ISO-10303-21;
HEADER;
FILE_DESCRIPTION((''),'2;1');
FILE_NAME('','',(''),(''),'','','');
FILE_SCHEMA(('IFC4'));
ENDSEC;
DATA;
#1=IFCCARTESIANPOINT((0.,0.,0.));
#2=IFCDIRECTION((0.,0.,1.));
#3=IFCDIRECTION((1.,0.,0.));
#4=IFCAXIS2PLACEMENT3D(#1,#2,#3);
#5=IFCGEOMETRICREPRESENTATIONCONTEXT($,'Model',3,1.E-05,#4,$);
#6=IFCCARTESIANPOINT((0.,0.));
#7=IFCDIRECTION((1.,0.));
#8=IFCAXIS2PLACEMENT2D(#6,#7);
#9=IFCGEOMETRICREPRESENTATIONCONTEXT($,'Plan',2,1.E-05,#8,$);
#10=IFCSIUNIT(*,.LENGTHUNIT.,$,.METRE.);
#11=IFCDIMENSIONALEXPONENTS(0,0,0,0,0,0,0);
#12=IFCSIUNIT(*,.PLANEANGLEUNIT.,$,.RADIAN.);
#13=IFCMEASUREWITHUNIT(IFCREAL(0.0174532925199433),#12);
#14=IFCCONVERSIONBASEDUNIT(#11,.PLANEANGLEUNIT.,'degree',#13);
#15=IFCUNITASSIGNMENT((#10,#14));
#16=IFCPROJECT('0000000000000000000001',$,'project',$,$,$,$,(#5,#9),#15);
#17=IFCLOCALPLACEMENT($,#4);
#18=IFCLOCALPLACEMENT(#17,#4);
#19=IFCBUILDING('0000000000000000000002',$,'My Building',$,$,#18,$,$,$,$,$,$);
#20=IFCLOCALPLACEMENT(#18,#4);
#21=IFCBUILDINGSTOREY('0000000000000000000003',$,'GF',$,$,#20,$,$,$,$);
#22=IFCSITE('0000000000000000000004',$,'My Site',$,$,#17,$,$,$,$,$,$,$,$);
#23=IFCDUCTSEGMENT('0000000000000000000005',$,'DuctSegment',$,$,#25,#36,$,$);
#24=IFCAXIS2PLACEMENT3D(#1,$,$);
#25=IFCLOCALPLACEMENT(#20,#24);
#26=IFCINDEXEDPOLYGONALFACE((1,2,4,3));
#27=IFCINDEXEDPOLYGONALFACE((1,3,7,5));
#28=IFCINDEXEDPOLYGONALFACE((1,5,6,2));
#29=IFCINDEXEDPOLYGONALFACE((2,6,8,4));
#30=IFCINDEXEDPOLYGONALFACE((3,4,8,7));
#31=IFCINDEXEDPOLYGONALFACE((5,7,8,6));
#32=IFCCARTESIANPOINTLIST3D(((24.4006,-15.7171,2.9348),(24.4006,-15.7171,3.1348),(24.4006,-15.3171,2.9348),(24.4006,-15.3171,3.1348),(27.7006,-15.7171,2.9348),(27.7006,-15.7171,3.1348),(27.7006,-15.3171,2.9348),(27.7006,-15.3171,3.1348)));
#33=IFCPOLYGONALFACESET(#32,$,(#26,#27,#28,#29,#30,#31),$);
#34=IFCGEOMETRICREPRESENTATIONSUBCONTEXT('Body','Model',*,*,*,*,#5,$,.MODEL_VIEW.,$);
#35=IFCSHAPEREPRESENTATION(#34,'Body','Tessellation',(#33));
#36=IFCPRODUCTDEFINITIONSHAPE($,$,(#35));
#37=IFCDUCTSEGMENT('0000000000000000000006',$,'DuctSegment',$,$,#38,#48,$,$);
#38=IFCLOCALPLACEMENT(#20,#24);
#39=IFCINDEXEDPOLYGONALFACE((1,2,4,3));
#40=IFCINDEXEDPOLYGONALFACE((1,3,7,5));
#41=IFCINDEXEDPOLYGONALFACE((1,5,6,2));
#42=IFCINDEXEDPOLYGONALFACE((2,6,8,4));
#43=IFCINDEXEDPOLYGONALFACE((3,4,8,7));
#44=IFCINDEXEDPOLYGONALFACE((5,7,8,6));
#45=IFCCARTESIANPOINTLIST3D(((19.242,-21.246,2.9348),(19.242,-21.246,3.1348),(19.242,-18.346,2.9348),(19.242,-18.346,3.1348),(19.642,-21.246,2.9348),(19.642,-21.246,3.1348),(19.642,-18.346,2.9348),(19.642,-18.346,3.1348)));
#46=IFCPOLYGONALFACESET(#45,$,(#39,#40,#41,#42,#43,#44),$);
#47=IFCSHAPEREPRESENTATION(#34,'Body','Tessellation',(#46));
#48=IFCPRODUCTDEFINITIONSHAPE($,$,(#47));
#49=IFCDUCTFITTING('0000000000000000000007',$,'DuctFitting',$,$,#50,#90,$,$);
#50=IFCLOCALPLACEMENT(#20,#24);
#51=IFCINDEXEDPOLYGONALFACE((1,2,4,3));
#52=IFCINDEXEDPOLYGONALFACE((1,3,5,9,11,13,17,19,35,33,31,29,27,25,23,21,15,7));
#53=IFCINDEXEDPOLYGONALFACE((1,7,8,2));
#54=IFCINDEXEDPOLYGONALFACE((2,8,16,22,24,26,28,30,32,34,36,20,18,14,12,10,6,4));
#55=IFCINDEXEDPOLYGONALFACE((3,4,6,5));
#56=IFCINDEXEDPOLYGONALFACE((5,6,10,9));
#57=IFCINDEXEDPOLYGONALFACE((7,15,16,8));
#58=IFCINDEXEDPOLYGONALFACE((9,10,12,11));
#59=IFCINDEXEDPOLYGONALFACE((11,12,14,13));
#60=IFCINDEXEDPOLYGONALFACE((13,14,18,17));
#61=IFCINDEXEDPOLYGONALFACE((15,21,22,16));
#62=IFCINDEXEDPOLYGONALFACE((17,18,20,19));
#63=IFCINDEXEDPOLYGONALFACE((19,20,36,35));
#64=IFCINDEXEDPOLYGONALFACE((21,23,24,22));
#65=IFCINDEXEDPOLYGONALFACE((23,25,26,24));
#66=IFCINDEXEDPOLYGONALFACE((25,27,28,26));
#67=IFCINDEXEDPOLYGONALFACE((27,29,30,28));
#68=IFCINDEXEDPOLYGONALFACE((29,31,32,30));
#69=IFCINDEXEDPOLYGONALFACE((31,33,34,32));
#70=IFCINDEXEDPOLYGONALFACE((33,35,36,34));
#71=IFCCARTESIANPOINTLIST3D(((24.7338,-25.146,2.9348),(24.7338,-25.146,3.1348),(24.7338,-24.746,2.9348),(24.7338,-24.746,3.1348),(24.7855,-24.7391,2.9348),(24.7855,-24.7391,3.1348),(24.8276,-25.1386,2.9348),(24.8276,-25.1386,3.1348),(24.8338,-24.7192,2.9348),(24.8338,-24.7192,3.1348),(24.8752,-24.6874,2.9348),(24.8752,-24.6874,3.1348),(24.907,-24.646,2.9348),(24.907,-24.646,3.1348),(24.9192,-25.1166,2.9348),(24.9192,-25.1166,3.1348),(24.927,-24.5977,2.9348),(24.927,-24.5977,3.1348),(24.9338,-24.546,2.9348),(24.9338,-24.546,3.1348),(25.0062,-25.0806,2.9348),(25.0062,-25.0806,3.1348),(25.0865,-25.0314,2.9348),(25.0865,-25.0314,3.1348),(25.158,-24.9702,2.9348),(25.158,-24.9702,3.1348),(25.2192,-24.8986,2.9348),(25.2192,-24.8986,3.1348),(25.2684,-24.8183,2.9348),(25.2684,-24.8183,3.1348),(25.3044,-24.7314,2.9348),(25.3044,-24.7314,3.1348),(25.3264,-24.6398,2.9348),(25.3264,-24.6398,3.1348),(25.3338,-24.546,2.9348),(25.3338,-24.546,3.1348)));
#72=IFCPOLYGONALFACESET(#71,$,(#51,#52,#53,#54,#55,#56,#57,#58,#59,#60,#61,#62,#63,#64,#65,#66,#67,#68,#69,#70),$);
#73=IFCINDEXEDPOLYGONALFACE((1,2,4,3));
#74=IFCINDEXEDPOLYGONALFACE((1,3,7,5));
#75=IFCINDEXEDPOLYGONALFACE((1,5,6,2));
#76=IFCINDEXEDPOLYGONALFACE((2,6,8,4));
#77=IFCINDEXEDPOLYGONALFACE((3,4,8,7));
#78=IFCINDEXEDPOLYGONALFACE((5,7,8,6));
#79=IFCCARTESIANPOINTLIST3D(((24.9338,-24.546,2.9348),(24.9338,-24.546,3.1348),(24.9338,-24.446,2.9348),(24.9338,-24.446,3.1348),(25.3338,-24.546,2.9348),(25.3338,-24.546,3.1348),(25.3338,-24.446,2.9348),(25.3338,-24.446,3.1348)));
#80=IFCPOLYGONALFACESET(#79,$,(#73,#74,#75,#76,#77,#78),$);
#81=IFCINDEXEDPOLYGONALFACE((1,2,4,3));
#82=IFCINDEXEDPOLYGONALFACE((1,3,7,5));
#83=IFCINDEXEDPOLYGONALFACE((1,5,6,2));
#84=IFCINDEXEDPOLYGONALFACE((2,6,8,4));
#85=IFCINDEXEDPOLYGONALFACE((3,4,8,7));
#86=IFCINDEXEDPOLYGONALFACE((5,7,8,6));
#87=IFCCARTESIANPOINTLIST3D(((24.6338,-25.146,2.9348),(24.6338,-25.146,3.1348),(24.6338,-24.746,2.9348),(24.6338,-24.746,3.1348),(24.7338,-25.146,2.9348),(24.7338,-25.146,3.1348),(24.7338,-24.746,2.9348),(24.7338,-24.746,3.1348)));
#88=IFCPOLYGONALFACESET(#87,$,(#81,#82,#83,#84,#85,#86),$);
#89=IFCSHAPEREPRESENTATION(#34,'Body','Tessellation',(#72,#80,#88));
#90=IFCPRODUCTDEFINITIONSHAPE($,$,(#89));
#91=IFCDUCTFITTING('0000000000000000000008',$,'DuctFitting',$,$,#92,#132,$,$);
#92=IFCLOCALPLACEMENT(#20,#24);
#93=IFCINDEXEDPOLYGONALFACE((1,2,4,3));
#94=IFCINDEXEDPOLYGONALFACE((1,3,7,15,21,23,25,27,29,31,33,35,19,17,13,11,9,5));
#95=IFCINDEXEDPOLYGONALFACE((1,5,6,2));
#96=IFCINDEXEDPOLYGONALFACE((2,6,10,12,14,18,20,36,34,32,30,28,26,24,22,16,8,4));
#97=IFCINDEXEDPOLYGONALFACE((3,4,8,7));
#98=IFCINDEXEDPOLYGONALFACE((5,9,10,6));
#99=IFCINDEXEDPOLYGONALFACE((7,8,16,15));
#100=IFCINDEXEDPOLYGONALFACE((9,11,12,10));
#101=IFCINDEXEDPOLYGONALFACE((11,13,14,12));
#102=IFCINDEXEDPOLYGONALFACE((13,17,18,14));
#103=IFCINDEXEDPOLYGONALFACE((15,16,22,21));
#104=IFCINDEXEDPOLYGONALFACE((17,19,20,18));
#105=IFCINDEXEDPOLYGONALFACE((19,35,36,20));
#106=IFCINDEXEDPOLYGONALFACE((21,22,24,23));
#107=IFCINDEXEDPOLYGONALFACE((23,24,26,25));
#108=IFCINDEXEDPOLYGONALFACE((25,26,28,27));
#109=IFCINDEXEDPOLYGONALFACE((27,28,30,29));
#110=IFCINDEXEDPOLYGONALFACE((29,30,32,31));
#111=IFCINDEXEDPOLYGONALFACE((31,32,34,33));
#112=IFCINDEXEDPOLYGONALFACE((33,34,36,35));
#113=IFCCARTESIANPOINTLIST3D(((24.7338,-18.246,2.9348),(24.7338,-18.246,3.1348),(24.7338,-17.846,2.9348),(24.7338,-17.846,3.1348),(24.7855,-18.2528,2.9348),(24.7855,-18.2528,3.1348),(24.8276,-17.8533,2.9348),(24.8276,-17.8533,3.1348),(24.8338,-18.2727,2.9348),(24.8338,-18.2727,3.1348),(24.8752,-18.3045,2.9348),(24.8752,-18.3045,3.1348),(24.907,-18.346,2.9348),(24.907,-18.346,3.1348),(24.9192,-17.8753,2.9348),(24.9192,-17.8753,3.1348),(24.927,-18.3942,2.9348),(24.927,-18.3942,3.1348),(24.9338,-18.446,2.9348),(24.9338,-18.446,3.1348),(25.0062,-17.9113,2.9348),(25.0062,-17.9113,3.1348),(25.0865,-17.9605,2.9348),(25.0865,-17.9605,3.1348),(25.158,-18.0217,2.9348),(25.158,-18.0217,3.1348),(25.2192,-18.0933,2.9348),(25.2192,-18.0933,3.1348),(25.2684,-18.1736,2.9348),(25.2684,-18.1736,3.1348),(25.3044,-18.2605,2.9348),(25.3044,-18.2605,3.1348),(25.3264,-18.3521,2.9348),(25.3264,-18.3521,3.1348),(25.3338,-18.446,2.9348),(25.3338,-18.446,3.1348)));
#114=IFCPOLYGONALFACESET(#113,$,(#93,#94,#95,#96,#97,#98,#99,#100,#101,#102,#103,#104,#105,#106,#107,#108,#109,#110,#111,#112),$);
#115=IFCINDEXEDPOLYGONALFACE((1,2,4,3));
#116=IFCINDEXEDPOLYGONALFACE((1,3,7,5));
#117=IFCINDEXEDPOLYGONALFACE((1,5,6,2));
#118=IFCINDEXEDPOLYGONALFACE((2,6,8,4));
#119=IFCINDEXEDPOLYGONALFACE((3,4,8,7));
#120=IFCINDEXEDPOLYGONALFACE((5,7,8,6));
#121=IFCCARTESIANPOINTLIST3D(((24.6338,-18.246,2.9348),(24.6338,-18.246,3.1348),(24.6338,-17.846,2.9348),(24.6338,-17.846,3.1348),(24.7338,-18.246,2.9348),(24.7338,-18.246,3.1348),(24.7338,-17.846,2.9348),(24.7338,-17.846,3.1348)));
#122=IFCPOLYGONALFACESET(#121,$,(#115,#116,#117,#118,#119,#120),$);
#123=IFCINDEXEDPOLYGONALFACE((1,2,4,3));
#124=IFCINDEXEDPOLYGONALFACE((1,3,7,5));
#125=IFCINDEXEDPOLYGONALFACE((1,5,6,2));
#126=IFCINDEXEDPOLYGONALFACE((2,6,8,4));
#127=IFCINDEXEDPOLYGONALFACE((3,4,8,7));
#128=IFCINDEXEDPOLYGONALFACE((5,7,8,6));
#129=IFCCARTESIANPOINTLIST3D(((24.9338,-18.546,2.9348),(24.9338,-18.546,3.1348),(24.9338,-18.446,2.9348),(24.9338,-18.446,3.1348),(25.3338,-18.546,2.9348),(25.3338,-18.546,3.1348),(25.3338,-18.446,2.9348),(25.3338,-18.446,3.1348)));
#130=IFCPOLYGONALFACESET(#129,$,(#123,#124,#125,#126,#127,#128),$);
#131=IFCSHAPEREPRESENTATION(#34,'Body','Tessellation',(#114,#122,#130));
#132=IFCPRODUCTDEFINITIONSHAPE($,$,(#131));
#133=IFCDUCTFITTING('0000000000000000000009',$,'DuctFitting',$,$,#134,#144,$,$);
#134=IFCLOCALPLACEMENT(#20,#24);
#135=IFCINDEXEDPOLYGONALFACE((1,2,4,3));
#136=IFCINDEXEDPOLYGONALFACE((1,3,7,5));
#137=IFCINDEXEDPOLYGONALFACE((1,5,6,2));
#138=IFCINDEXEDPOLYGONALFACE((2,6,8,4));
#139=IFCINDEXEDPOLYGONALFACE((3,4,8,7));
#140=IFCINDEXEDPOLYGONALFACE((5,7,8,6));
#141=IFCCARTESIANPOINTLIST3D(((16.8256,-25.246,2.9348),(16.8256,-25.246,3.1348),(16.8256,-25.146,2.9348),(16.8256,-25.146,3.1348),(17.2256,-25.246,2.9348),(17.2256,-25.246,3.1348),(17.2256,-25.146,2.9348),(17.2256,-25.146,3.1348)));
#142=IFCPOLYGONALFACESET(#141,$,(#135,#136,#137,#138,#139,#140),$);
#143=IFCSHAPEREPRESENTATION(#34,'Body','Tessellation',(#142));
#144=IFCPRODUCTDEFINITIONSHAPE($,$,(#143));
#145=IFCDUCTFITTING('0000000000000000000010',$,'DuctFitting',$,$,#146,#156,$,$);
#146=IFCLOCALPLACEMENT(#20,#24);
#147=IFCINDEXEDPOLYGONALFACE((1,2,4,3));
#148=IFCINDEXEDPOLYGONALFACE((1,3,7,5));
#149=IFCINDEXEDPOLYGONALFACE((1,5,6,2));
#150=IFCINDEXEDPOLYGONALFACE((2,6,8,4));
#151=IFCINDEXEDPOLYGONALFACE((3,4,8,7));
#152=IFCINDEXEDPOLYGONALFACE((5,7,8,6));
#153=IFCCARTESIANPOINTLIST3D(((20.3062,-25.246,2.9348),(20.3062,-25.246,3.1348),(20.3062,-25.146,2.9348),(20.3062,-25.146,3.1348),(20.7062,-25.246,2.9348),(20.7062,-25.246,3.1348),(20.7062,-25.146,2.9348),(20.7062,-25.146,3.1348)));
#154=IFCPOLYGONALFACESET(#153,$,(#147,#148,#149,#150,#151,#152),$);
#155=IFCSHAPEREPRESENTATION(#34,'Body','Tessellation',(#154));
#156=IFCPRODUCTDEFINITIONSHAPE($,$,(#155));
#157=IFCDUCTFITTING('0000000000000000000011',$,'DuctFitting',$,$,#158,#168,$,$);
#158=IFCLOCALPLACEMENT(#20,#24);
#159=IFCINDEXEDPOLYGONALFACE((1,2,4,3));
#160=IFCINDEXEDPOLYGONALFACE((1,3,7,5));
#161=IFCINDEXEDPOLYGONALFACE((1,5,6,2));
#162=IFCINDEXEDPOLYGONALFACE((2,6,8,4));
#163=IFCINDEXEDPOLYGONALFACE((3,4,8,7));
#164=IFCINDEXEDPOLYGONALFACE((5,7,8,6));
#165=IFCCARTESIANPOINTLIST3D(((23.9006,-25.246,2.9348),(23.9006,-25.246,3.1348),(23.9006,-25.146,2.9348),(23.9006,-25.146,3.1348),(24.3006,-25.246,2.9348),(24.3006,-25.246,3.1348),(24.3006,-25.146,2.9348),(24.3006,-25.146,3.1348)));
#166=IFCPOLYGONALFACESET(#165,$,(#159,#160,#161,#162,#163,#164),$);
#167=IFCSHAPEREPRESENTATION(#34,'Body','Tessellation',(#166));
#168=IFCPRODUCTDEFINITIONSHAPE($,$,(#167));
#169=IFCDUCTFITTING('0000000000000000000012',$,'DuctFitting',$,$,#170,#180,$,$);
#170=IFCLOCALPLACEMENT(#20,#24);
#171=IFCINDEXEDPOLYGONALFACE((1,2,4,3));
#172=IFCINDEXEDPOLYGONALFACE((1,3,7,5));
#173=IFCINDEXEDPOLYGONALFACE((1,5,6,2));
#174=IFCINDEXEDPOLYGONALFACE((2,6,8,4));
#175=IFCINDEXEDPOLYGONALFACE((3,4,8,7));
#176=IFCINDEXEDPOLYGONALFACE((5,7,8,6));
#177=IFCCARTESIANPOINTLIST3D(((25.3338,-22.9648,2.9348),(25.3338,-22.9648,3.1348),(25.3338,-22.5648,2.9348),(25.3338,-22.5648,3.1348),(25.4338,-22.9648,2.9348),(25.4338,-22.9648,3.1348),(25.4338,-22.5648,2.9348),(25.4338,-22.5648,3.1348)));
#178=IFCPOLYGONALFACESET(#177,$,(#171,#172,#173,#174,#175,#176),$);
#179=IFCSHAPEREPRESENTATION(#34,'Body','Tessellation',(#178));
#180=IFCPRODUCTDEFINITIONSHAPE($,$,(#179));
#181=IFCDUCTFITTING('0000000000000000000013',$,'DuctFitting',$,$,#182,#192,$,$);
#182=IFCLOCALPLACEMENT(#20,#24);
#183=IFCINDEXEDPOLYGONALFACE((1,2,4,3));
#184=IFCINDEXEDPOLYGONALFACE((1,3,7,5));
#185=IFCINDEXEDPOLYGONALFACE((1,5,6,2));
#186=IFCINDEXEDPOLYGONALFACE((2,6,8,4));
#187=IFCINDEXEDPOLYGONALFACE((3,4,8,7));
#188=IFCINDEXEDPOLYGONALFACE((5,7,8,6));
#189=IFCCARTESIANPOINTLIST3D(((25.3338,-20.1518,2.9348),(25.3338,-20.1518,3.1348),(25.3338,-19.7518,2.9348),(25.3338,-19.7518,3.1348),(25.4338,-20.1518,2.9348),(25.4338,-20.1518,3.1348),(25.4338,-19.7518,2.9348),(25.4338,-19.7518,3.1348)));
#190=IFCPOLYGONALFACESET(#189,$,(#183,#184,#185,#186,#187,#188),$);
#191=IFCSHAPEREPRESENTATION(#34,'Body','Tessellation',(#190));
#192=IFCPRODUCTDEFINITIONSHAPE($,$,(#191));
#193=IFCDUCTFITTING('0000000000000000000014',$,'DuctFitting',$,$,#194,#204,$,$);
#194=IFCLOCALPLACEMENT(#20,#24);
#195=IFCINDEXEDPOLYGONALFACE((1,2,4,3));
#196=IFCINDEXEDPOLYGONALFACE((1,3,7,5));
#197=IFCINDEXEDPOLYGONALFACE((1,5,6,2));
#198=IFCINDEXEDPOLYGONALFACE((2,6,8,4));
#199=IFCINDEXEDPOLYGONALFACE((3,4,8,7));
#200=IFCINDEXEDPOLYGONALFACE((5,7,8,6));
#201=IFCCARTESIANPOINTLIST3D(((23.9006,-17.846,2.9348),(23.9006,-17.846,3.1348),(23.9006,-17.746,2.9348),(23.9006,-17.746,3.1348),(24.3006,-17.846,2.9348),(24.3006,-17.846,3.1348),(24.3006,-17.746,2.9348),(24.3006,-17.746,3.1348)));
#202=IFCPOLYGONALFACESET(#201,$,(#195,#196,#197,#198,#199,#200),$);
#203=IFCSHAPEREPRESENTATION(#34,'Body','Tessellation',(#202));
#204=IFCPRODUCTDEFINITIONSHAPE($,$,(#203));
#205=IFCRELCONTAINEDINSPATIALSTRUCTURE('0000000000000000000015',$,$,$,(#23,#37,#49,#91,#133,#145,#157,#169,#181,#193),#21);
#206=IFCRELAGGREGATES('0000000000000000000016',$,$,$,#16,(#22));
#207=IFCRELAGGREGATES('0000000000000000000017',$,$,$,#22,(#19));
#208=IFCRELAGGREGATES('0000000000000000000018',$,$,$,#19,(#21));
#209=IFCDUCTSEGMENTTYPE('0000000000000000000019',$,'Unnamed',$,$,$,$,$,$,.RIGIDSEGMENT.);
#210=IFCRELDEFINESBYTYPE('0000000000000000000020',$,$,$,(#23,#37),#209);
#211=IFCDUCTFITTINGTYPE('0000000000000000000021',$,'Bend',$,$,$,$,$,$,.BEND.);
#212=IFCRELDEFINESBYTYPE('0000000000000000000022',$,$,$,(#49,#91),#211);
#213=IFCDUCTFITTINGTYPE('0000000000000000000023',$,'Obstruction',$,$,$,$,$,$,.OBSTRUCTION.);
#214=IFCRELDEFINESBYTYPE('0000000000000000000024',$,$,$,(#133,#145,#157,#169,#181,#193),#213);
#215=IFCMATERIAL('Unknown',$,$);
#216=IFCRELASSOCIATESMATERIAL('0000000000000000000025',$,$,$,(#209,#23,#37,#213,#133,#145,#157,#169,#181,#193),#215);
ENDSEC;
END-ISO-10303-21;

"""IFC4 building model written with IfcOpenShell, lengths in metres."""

from ifc_helpers import new_model, entity, si_unit, converted_unit, frame, origin_with_axes, origin_2d_with_axis, place, context, subcontext, project, spatial, line, arc, indexed_curve, rectangle, outline, extrude, source, transform, mapped, material, material_profile, profile_set, profile_usage, type_object, type_shapes, element, save


model = new_model("IFC4")

# Units and contexts
model_context = context("Model", 3, precision=1e-05, world=origin_with_axes())
plan_context = context("Plan", 2, precision=1e-05, world=origin_2d_with_axis())
body_context_1 = subcontext(model_context, "Body", "Model", "MODEL_VIEW")
ifc_project = project(units=[si_unit("LENGTHUNIT", "METRE"), converted_unit("PLANEANGLEUNIT", "degree", entity("IfcReal", 0.0174532925199433), si_unit("PLANEANGLEUNIT", "RADIAN"), dimensions=[0, 0, 0, 0, 0, 0, 0])], contexts=[model_context, plan_context])

# Site, building, storey
site_placement = place(None, origin_with_axes())
site = spatial("IfcSite", under=ifc_project, at=site_placement, Name="My Site")
building_placement = place(site_placement, origin_with_axes())
building = spatial("IfcBuilding", under=site, at=building_placement, Name="My Building")
storey_placement = place(building_placement, origin_with_axes())
storey = spatial("IfcBuildingStorey", under=building, at=storey_placement, Name="GF")

# Shared definitions
ifc_material = material(Name="Unknown")

# Duct segments
ifc_material_profile_1 = material_profile(ifc_material, rectangle(XDim=0.4, YDim=0.2))
ifc_profile_set_1 = profile_set([ifc_material_profile_1])
duct_segment_type = type_object("IfcDuctSegmentType", Name="Unnamed", PredefinedType="RIGIDSEGMENT", material=ifc_profile_set_1)
ifc_profile_usage_1 = profile_usage(ifc_profile_set_1, cardinal=5)
duct_segment_1_placement = place(storey_placement, frame((24.4006, -15.5171, 3.0348), z_axis=(1.0, 0.0, 0.0), x_axis=(0.0, 1.0, 0.0)))
element("IfcDuctSegment", 1, at=duct_segment_1_placement, inside=storey, type_object=duct_segment_type, material=ifc_profile_usage_1, Name="DuctSegment", context=body_context_1, shape_type="SweptSolid", body=[
    extrude(rectangle(XDim=0.4, YDim=0.2), origin_with_axes(), (0.0, 0.0, 1.0), 3.3),
])
ifc_profile_usage_2 = profile_usage(ifc_profile_set_1, cardinal=5)
duct_segment_2_placement = place(storey_placement, frame((19.442, -18.346, 3.0348), z_axis=(0.0, -1.0, 0.000001), x_axis=(1.0, 0.0, 0.0)))
element("IfcDuctSegment", 2, at=duct_segment_2_placement, inside=storey, type_object=duct_segment_type, material=ifc_profile_usage_2, Name="DuctSegment", context=body_context_1, shape_type="SweptSolid", body=[
    extrude(rectangle(XDim=0.4, YDim=0.2), origin_with_axes(), (0.0, 0.0, 1.0), 2.9),
])

# Duct fittings
duct_fitting_type_1 = type_object("IfcDuctFittingType", Name="Bend", PredefinedType="BEND")
shared_shape_1 = source(origin_with_axes(), body_context_1, "Body", "SweptSolid", [
    extrude(outline(indexed_curve([(0.2, 0.0), (0.2586, 0.1414), (0.4, 0.2), (0.4, 0.6), (-0.0243, 0.4243), (-0.2, 0.0)], segments=[arc(1, 2, 3), line(3, 4), arc(4, 5, 6), line(6, 1)])), frame((0.0, -0.1, 0.1), z_axis=(0.0, -1.0, 0.0), x_axis=(1.0, 0.0, 0.0)), (0.0, 0.0, -1.0), 0.2),
    extrude(rectangle(XDim=0.4, YDim=0.2), origin_with_axes(), (0.0, 0.0, 1.0), 0.1),
    extrude(rectangle(XDim=0.4, YDim=0.2), frame((0.4, 0.0, 0.5), z_axis=(1.0, 0.0, 0.0), x_axis=(0.0, 0.0, 1.0)), (0.0, 0.0, 1.0), 0.1),
])
type_shapes(duct_fitting_type_1, [shared_shape_1])
for number, where, z_axis, x_axis, name in (
    (3, (25.1338, -24.446, 3.0348), (0.0, -1.0, 0.0), (-1.0, 0.0, 0.0), "DuctFitting"),
    (4, (24.6338, -18.046, 3.0348), (1.0, 0.0, 0.0), (0.0, -1.0, 0.0), "DuctFitting"),
):
    element("IfcDuctFitting", number, at=place(storey_placement, frame(where, z_axis=z_axis, x_axis=x_axis)), inside=storey, type_object=duct_fitting_type_1, Name=name, context=body_context_1, shape_type="MappedRepresentation", body=[
        mapped(shared_shape_1, transform((0.0, 0.0, 0.0), x_axis=(1.0, 0.0, 0.0), y_axis=(0.0, 1.0, 0.0), z_axis=(0.0, 0.0, 1.0), scale=1.0)),
    ])
ifc_material_profile_2 = material_profile(ifc_material, rectangle(XDim=0.4, YDim=0.2))
ifc_profile_set_2 = profile_set([ifc_material_profile_2])
ifc_profile_usage_3 = profile_usage(ifc_profile_set_2, cardinal=5)
duct_fitting_type_2 = type_object("IfcDuctFittingType", Name="Obstruction", PredefinedType="OBSTRUCTION", material=ifc_profile_set_2)
duct_fitting_1_placement = place(storey_placement, frame((17.0256, -25.146, 3.0348), z_axis=(0.0, -1.0, 0.000001), x_axis=(1.0, 0.0, 0.0)))
element("IfcDuctFitting", 5, at=duct_fitting_1_placement, inside=storey, type_object=duct_fitting_type_2, material=ifc_profile_usage_3, Name="DuctFitting", context=body_context_1, shape_type="SweptSolid", body=[
    extrude(rectangle(XDim=0.4, YDim=0.2), origin_with_axes(), (0.0, 0.0, 1.0), 0.1),
])
ifc_profile_usage_4 = profile_usage(ifc_profile_set_2, cardinal=5)
duct_fitting_2_placement = place(storey_placement, frame((20.5062, -25.146, 3.0348), z_axis=(0.0, -1.0, 0.000001), x_axis=(1.0, 0.0, 0.0)))
element("IfcDuctFitting", 6, at=duct_fitting_2_placement, inside=storey, type_object=duct_fitting_type_2, material=ifc_profile_usage_4, Name="DuctFitting", context=body_context_1, shape_type="SweptSolid", body=[
    extrude(rectangle(XDim=0.4, YDim=0.2), origin_with_axes(), (0.0, 0.0, 1.0), 0.1),
])
ifc_profile_usage_5 = profile_usage(ifc_profile_set_2, cardinal=5)
duct_fitting_3_placement = place(storey_placement, frame((24.1006, -25.146, 3.0348), z_axis=(0.0, -1.0, 0.000001), x_axis=(1.0, 0.0, 0.0)))
element("IfcDuctFitting", 7, at=duct_fitting_3_placement, inside=storey, type_object=duct_fitting_type_2, material=ifc_profile_usage_5, Name="DuctFitting", context=body_context_1, shape_type="SweptSolid", body=[
    extrude(rectangle(XDim=0.4, YDim=0.2), origin_with_axes(), (0.0, 0.0, 1.0), 0.1),
])
ifc_profile_usage_6 = profile_usage(ifc_profile_set_2, cardinal=5)
duct_fitting_4_placement = place(storey_placement, frame((25.3338, -22.7648, 3.0348), z_axis=(1.0, -0.000001, 0.000001), x_axis=(0.000001, 1.0, 0.0)))
element("IfcDuctFitting", 8, at=duct_fitting_4_placement, inside=storey, type_object=duct_fitting_type_2, material=ifc_profile_usage_6, Name="DuctFitting", context=body_context_1, shape_type="SweptSolid", body=[
    extrude(rectangle(XDim=0.4, YDim=0.2), origin_with_axes(), (0.0, 0.0, 1.0), 0.1),
])
ifc_profile_usage_7 = profile_usage(ifc_profile_set_2, cardinal=5)
duct_fitting_5_placement = place(storey_placement, frame((25.3338, -19.9518, 3.0348), z_axis=(1.0, -0.000001, 0.000001), x_axis=(0.000001, 1.0, 0.0)))
element("IfcDuctFitting", 9, at=duct_fitting_5_placement, inside=storey, type_object=duct_fitting_type_2, material=ifc_profile_usage_7, Name="DuctFitting", context=body_context_1, shape_type="SweptSolid", body=[
    extrude(rectangle(XDim=0.4, YDim=0.2), origin_with_axes(), (0.0, 0.0, 1.0), 0.1),
])
ifc_profile_usage_8 = profile_usage(ifc_profile_set_2, cardinal=5)
duct_fitting_6_placement = place(storey_placement, frame((24.1006, -17.746, 3.0348), z_axis=(0.0, -1.0, 0.000001), x_axis=(1.0, 0.0, 0.0)))
element("IfcDuctFitting", 10, at=duct_fitting_6_placement, inside=storey, type_object=duct_fitting_type_2, material=ifc_profile_usage_8, Name="DuctFitting", context=body_context_1, shape_type="SweptSolid", body=[
    extrude(rectangle(XDim=0.4, YDim=0.2), origin_with_axes(), (0.0, 0.0, 1.0), 0.1),
])

save(model, "model.ifc")
